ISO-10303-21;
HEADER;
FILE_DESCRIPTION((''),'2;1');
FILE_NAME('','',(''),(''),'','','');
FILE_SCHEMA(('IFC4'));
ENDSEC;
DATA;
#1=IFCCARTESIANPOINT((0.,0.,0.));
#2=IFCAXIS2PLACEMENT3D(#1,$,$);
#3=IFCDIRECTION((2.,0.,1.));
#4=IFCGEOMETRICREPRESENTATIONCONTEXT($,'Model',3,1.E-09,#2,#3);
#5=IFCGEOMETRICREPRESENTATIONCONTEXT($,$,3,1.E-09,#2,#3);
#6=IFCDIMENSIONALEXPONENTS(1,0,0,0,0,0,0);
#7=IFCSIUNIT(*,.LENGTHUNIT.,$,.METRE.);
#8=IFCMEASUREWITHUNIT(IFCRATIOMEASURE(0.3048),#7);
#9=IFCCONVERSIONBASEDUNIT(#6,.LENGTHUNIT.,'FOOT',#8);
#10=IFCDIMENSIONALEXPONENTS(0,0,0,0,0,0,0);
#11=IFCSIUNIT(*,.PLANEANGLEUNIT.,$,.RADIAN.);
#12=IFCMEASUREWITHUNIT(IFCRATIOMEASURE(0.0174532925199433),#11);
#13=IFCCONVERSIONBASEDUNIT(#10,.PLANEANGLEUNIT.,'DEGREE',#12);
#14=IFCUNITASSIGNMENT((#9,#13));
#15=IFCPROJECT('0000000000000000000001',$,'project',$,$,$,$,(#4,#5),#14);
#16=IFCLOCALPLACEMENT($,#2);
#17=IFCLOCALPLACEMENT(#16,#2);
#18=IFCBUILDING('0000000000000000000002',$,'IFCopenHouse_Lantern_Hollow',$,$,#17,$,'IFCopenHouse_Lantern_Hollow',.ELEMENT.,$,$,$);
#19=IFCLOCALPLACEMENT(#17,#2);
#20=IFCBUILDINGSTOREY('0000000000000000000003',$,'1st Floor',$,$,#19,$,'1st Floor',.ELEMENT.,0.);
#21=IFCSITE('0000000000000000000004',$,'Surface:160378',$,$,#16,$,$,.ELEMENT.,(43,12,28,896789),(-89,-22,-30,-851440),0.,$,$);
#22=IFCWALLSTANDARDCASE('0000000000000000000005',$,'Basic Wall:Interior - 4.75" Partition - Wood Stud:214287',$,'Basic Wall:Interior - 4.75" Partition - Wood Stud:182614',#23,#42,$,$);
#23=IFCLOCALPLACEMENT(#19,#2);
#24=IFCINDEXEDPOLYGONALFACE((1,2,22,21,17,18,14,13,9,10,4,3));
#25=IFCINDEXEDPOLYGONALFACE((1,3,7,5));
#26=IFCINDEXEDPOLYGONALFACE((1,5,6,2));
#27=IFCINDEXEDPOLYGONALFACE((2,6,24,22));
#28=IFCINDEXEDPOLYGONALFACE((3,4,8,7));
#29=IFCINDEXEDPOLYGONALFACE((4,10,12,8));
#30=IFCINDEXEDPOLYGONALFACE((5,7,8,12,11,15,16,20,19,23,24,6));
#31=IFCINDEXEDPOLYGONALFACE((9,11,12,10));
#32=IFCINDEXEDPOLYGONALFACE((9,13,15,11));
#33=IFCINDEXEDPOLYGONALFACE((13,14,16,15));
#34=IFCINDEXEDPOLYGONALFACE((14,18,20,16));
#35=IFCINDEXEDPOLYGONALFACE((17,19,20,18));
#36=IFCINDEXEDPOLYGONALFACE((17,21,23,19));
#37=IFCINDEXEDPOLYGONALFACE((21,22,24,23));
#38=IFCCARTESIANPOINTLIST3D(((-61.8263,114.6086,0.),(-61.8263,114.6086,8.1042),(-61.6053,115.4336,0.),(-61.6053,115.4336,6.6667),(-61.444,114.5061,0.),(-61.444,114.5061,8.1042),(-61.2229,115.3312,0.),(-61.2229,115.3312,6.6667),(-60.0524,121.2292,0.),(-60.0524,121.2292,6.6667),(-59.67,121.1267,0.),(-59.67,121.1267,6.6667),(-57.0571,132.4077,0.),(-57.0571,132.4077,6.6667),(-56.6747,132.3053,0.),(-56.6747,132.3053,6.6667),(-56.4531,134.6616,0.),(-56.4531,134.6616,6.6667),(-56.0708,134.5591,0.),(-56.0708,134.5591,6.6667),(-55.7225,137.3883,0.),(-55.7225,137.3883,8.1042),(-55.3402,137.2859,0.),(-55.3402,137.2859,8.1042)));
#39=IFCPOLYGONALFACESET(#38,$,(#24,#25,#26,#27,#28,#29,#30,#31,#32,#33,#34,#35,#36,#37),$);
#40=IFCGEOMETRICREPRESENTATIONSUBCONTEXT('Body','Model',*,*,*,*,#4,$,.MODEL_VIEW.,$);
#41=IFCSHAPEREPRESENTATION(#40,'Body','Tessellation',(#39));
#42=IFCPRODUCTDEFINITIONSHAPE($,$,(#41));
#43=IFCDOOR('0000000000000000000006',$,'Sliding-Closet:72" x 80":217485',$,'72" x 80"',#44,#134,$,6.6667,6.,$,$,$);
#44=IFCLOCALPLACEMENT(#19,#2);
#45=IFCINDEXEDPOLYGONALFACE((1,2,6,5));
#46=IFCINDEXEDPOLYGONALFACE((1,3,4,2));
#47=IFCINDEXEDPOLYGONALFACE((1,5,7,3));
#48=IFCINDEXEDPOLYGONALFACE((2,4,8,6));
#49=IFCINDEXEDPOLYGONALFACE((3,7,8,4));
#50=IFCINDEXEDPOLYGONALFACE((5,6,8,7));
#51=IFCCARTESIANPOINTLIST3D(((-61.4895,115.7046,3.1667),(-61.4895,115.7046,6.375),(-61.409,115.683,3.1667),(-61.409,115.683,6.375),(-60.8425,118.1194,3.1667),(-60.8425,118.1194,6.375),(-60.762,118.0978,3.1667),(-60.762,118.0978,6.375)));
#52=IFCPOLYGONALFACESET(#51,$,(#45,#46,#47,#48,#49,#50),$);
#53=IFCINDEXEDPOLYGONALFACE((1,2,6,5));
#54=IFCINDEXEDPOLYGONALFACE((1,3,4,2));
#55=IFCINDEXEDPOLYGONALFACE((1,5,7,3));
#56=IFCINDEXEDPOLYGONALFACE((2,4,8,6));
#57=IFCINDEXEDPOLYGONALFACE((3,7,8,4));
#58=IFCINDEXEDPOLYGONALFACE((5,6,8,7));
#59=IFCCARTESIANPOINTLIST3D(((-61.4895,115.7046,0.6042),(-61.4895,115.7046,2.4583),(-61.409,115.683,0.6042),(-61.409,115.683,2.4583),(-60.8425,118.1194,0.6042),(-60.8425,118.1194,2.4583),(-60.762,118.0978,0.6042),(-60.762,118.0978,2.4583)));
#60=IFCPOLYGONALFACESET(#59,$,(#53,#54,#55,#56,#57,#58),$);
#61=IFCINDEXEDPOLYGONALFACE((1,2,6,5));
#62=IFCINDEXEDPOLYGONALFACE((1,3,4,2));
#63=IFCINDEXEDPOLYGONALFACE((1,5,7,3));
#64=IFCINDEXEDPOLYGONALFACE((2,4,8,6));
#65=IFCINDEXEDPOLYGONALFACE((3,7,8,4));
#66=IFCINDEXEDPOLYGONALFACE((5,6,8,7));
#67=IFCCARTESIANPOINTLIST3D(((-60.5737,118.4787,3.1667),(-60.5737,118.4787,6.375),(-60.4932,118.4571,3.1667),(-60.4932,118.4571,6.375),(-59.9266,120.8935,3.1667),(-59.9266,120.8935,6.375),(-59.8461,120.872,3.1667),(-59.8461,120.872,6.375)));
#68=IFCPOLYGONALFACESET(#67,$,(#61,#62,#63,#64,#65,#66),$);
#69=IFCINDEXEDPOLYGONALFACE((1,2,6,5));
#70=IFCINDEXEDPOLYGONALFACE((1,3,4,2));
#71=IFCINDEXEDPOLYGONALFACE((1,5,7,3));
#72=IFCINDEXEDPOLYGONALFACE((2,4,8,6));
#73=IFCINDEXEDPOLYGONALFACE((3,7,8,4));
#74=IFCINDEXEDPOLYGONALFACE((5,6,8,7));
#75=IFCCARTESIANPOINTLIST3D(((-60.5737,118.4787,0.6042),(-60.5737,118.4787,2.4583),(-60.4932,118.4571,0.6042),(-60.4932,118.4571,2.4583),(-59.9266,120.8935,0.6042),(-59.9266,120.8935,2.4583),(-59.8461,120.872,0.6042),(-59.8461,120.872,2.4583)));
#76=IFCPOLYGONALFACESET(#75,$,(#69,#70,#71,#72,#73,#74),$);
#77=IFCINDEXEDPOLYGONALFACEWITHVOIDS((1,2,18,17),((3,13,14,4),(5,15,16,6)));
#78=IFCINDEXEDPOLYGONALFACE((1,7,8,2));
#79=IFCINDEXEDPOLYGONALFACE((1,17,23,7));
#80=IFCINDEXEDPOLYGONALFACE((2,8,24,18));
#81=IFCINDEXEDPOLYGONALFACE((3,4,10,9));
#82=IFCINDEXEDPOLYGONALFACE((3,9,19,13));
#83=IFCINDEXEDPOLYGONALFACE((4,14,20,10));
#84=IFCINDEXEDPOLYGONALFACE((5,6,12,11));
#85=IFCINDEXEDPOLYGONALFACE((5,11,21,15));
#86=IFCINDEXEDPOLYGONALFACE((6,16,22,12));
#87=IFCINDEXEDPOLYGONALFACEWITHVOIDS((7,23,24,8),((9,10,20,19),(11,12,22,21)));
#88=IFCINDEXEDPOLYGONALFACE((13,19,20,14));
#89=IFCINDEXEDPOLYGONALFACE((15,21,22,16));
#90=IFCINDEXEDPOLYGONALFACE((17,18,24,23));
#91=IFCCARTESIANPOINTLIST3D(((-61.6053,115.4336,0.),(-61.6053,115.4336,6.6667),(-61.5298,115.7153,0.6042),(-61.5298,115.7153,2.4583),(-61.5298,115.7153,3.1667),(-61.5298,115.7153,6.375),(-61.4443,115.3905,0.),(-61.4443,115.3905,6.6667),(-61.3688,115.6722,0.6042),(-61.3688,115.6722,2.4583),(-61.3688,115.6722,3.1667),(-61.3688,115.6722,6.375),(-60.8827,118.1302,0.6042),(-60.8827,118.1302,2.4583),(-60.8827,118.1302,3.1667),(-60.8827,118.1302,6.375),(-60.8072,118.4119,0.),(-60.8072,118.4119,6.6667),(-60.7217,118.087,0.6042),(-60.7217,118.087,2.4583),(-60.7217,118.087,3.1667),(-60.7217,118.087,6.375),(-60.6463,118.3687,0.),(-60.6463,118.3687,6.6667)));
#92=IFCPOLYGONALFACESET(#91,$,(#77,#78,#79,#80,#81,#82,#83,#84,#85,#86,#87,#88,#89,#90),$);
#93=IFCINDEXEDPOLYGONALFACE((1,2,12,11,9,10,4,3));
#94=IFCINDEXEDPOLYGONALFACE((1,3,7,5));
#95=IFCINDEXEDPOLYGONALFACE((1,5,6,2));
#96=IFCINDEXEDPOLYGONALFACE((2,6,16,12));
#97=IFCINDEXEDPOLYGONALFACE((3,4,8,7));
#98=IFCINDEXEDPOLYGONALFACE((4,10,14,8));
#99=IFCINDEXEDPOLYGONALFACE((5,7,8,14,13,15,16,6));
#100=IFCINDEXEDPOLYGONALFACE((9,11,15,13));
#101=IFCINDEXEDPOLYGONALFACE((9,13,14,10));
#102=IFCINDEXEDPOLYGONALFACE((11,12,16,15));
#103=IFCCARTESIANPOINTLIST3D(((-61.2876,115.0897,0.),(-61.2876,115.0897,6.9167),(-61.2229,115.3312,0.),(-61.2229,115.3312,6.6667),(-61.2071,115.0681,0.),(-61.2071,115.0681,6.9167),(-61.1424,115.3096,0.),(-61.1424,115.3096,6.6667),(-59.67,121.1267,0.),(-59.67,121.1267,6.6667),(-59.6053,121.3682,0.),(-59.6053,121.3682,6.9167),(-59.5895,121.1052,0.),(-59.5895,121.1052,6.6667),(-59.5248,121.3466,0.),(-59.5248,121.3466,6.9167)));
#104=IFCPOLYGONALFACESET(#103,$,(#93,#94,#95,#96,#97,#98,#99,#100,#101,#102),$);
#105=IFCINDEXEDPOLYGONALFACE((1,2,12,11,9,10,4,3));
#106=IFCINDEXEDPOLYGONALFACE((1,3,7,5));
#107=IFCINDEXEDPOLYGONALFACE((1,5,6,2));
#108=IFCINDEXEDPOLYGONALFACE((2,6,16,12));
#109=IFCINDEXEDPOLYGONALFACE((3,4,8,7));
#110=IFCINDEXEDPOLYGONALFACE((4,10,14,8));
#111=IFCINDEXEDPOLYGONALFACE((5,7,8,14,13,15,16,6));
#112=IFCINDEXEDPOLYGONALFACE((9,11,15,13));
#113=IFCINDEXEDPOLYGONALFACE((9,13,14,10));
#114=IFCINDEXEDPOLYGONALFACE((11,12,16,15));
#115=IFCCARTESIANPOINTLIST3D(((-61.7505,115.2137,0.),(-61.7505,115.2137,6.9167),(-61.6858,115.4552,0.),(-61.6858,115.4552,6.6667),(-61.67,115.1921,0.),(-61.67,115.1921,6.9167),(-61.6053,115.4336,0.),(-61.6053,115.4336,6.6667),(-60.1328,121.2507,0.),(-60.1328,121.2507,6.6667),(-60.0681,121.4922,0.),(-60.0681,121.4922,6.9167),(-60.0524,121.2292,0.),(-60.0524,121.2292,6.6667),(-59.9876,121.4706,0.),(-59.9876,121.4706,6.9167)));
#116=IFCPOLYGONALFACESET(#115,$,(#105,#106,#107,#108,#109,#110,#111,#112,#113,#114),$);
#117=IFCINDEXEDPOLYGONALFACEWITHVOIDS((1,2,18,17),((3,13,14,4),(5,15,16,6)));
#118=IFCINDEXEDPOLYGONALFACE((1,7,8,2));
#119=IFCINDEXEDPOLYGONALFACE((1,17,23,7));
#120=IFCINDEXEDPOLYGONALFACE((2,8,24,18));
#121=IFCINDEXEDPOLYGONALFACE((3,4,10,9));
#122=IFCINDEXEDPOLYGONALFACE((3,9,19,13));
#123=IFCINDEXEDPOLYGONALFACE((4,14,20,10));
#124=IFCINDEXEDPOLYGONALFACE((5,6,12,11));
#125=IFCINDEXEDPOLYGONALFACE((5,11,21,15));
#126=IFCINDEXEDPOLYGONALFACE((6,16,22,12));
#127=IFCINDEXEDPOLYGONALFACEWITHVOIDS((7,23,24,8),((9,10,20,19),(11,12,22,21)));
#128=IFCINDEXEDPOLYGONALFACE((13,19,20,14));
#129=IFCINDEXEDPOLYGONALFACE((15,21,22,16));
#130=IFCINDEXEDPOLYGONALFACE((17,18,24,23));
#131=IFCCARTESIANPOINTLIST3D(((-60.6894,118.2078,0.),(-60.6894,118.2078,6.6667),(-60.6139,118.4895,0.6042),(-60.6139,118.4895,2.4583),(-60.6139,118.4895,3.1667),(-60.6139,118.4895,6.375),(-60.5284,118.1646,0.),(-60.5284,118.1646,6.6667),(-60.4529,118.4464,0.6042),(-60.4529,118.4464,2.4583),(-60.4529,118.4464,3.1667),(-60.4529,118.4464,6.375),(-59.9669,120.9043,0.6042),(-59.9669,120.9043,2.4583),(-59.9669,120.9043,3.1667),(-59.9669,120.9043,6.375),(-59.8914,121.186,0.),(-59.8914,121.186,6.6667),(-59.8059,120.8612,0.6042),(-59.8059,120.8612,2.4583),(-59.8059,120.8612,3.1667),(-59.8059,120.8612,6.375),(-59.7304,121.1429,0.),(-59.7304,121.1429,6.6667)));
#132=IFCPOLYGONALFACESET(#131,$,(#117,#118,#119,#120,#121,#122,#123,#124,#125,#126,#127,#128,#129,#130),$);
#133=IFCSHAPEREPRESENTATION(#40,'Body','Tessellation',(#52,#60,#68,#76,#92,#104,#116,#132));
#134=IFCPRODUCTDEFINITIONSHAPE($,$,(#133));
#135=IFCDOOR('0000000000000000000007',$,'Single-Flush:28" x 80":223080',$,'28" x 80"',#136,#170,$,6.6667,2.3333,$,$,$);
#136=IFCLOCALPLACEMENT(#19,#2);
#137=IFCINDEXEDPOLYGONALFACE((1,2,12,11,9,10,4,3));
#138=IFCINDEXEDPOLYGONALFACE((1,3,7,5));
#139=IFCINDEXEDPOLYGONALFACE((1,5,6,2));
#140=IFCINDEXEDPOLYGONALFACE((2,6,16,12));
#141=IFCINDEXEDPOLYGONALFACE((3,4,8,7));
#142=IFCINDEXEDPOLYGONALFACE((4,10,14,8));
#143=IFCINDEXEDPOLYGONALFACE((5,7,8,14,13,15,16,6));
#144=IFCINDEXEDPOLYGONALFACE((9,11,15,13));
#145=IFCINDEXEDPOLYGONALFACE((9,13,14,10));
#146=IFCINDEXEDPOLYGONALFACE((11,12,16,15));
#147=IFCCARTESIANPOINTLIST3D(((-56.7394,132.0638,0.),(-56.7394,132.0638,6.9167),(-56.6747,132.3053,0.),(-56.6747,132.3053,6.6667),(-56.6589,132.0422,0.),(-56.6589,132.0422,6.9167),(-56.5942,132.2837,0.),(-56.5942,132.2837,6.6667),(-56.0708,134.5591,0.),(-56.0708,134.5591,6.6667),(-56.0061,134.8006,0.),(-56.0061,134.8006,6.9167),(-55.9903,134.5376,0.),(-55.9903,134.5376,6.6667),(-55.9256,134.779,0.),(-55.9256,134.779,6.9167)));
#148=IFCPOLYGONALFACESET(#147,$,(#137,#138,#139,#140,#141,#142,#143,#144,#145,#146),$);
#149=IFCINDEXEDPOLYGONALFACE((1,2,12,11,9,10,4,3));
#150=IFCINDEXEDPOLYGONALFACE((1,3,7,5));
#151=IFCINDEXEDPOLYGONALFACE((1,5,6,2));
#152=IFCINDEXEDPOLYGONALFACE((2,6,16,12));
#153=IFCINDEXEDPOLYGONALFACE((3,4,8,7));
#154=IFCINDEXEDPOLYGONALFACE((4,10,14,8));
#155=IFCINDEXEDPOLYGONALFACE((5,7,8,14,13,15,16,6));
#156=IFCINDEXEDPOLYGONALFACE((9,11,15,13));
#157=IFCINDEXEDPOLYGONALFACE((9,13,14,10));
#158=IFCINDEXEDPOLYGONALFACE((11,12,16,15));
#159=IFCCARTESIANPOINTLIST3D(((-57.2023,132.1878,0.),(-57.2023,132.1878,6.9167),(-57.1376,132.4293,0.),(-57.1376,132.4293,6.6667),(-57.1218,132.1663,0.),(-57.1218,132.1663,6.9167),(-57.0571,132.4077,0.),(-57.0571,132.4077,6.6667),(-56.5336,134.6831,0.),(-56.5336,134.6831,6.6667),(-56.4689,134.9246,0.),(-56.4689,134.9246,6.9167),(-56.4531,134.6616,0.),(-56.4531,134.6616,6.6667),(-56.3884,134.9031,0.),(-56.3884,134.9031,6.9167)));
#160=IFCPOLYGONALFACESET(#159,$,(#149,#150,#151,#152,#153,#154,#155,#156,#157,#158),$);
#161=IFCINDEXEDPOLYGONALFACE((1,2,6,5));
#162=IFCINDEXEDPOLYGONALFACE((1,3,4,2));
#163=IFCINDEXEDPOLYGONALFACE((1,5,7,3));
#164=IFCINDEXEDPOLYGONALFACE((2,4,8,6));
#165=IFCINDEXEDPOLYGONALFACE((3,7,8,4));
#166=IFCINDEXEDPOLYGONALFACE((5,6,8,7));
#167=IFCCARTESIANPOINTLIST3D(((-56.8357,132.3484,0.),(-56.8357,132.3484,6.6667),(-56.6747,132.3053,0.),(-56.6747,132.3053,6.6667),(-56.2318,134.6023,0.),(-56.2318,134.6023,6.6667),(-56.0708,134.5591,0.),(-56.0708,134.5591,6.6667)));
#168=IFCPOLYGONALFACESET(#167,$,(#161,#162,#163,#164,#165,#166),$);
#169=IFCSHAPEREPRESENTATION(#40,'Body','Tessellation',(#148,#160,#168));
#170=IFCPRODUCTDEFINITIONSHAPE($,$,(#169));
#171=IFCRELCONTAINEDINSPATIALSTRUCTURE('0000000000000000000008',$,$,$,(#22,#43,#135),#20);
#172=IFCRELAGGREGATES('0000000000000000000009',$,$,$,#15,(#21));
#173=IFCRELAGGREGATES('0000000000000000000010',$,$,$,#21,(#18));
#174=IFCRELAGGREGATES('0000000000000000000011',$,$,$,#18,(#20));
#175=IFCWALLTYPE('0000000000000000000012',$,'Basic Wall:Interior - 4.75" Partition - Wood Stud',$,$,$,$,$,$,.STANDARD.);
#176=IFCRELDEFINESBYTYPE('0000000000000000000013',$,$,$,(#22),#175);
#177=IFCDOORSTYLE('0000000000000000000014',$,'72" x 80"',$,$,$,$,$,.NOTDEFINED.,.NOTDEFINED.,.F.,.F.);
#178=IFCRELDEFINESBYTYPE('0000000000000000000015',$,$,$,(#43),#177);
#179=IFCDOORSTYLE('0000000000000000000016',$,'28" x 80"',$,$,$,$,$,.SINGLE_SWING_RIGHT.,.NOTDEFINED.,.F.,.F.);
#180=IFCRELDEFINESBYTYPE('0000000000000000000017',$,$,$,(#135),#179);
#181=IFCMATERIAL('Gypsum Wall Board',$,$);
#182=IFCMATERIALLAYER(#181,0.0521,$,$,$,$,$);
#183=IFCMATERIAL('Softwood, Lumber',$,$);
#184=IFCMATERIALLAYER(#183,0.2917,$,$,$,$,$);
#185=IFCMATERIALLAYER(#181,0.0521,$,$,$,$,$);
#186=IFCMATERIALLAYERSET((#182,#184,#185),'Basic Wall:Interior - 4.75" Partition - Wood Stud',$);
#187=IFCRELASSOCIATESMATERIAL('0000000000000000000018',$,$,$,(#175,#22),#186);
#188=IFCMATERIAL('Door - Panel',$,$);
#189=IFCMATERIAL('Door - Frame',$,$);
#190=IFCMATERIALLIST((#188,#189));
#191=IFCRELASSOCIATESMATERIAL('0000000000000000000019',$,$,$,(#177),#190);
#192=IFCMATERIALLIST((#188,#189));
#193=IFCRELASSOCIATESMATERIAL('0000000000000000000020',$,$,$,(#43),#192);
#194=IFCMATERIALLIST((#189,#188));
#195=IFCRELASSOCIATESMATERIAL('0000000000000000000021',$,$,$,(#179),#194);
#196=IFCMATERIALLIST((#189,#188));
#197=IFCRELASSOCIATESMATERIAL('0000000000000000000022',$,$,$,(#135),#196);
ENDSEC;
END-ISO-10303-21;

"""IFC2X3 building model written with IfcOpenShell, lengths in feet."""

from ifc_helpers import new_model, entity, si_unit, converted_unit, direction, frame, frame_2d, origin, origin_2d_with_axis, place, context, subcontext, project, spatial, polyline, rectangle, outline, extrude, source, transform, mapped, material, material_list, layer, layer_set, layer_usage, type_object, type_shapes, element, fill, save


model = new_model("IFC2X3")

# Units and contexts
model_context = context("Model", 3, precision=1e-09, world=origin(), true_north=direction((2.0, 0.0, 1.0)))
context_of_model = context(None, 3, precision=1e-09, world=origin(), true_north=direction((2.0, 0.0, 1.0)))
body_context = subcontext(model_context, "Body", "Model", "MODEL_VIEW")
ifc_project = project(units=[converted_unit("LENGTHUNIT", "FOOT", entity("IfcRatioMeasure", 0.3048), si_unit("LENGTHUNIT", "METRE"), dimensions=[1, 0, 0, 0, 0, 0, 0]), converted_unit("PLANEANGLEUNIT", "DEGREE", entity("IfcRatioMeasure", 0.0174532925199433), si_unit("PLANEANGLEUNIT", "RADIAN"), dimensions=[0, 0, 0, 0, 0, 0, 0])], contexts=[model_context, context_of_model])

# Site, building, storey
site_placement = place(None, origin())
site = spatial("IfcSite", under=ifc_project, at=site_placement, Name="Surface:160378", CompositionType="ELEMENT", RefLatitude=(43, 12, 28, 896789), RefLongitude=(-89, -22, -30, -851440), RefElevation=0.0)
building_placement = place(site_placement, origin())
building = spatial("IfcBuilding", under=site, at=building_placement, Name="IFCopenHouse_Lantern_Hollow", LongName="IFCopenHouse_Lantern_Hollow", CompositionType="ELEMENT")
storey_placement = place(building_placement, origin())
storey = spatial("IfcBuildingStorey", under=building, at=storey_placement, Name="1st Floor", LongName="1st Floor", CompositionType="ELEMENT", Elevation=0.0)

# Shared definitions
ifc_material_1 = material(Name="Softwood, Lumber")

# Shared definitions
ifc_material_2 = material(Name="Gypsum Wall Board")

# Shared definitions
ifc_layer_1 = layer(ifc_material_2, 0.0521)
ifc_layer_2 = layer(ifc_material_1, 0.2917)
ifc_layer_3 = layer(ifc_material_2, 0.0521)
ifc_layer_set_1 = layer_set([ifc_layer_1, ifc_layer_2, ifc_layer_3], Name="Basic Wall:Interior - 4.75\" Partition - Wood Stud")
wall_type_1 = type_object("IfcWallType", Name="Basic Wall:Interior - 4.75\" Partition - Wood Stud", PredefinedType="STANDARD", material=ifc_layer_set_1)

# Wall, openings, doors
ifc_layer_usage_1 = layer_usage(ifc_layer_set_1, "AXIS2", "NEGATIVE", 0.1979)
wall_1_placement = place(storey_placement, frame((-61.6352, 114.5573, 0.0), z_axis=(0.0, 0.0, 1.0), x_axis=(0.258819, 0.965926, 0.0)))
wall_1 = element("IfcWallStandardCase", 1, at=wall_1_placement, inside=storey, type_object=wall_type_1, material=ifc_layer_usage_1, Name="Basic Wall:Interior - 4.75\" Partition - Wood Stud:214287", ObjectType="Basic Wall:Interior - 4.75\" Partition - Wood Stud:182614", context=body_context, shape_type="SweptSolid", body=[
    extrude(rectangle(XDim=23.5833, YDim=0.3958, at=frame_2d((11.7917, 0.0), x_axis=(-1.0, 0.0))), origin(), (0.0, 0.0, 1.0), 8.1042),
])
opening_1_placement = place(wall_1_placement, frame((0.8542, -0.1979, 0.0)))
opening_1 = element("IfcOpeningElement", 2, at=opening_1_placement, cuts=wall_1, ObjectType="Opening", context=body_context, shape_type="SweptSolid", body=[
    extrude(rectangle(XDim=6.6667, YDim=6.0, at=frame_2d((3.3333, 3.0), x_axis=(-1.0, 0.0))), frame((0.0, 0.0, 0.0), z_axis=(0.0, 1.0, 0.0), x_axis=(0.0, 0.0, 1.0)), (0.0, 0.0, 1.0), 0.3958),
])
opening_2_placement = place(wall_1_placement, frame((20.7604, 0.1979, 0.0)))
opening_2 = element("IfcOpeningElement", 3, at=opening_2_placement, cuts=wall_1, ObjectType="Opening", context=body_context, shape_type="SweptSolid", body=[
    extrude(rectangle(XDim=2.3333, YDim=6.6667, at=frame_2d((3.3333, 1.1667), x_axis=(0.0, 1.0))), frame((0.0, 0.0, 0.0), z_axis=(0.0, -1.0, 0.0), x_axis=(0.0, 0.0, 1.0)), (0.0, 0.0, 1.0), 0.3958),
])
ifc_material_3 = material(Name="Door - Panel")
ifc_material_4 = material(Name="Door - Frame")
ifc_material_list_1 = material_list([ifc_material_3, ifc_material_4])
ifc_material_list_2 = material_list([ifc_material_3, ifc_material_4])
door_style_1 = type_object("IfcDoorStyle", Name="72\" x 80\"", ConstructionType="NOTDEFINED", OperationType="NOTDEFINED", ParameterTakesPrecedence=False, Sizeable=False, material=ifc_material_list_2)
shared_shape_1 = source(origin(), body_context, "Body", "SweptSolid", [
    extrude(rectangle(XDim=0.0833, YDim=2.5, at=origin_2d_with_axis()), frame((1.5417, 0.3125, 3.1667), z_axis=(0.0, 0.0, 1.0), x_axis=(0.0, 1.0, 0.0)), (0.0, 0.0, 1.0), 3.2083),
    extrude(rectangle(XDim=0.0833, YDim=2.5, at=origin_2d_with_axis()), frame((1.5417, 0.3125, 0.6042), z_axis=(0.0, 0.0, 1.0), x_axis=(0.0, 1.0, 0.0)), (0.0, 0.0, 1.0), 1.8542),
    extrude(rectangle(XDim=0.0833, YDim=2.5, at=origin_2d_with_axis()), frame((4.4583, 0.1458, 3.1667), z_axis=(0.0, 0.0, 1.0), x_axis=(0.0, -1.0, 0.0)), (0.0, 0.0, 1.0), 3.2083),
    extrude(rectangle(XDim=0.0833, YDim=2.5, at=origin_2d_with_axis()), frame((4.4583, 0.1458, 0.6042), z_axis=(0.0, 0.0, 1.0), x_axis=(0.0, -1.0, 0.0)), (0.0, 0.0, 1.0), 1.8542),
    extrude(outline(polyline([(-3.3333, -1.5417), (3.3333, -1.5417), (3.3333, 1.5417), (-3.3333, 1.5417), (-3.3333, -1.5417)]), holes=[polyline([(2.7292, 1.25), (2.7292, -1.25), (0.875, -1.25), (0.875, 1.25), (2.7292, 1.25)]), polyline([(0.1667, 1.25), (0.1667, -1.25), (-3.0417, -1.25), (-3.0417, 1.25), (0.1667, 1.25)])]), frame((1.5417, 0.2292, 3.3333), z_axis=(0.0, 1.0, 0.0), x_axis=(0.0, 0.0, -1.0)), (0.0, 0.0, 1.0), 0.1667),
    extrude(outline(polyline([(-3.3958, -3.25), (3.5208, -3.25), (3.5208, 3.25), (-3.3958, 3.25), (-3.3958, 3.0), (3.2708, 3.0), (3.2708, -3.0), (-3.3958, -3.0), (-3.3958, -3.25)])), frame((3.0, -0.0833, 3.3958), z_axis=(0.0, 1.0, 0.0), x_axis=(0.0, 0.0, 1.0)), (0.0, 0.0, 1.0), 0.0833),
    extrude(outline(polyline([(-3.25, -3.3958), (-3.0, -3.3958), (-3.0, 3.2708), (3.0, 3.2708), (3.0, -3.3958), (3.25, -3.3958), (3.25, 3.5208), (-3.25, 3.5208), (-3.25, -3.3958)])), frame((3.0, 0.3958, 3.3958), z_axis=(0.0, 1.0, 0.0), x_axis=(-1.0, 0.0, 0.0)), (0.0, 0.0, 1.0), 0.0833),
    extrude(outline(polyline([(-1.5417, -3.3333), (1.5417, -3.3333), (1.5417, 3.3333), (-1.5417, 3.3333), (-1.5417, -3.3333)]), holes=[polyline([(1.25, 0.1667), (1.25, -3.0417), (-1.25, -3.0417), (-1.25, 0.1667), (1.25, 0.1667)]), polyline([(1.25, 2.7292), (1.25, 0.875), (-1.25, 0.875), (-1.25, 2.7292), (1.25, 2.7292)])]), frame((4.4583, 0.0625, 3.3333), z_axis=(0.0, 1.0, 0.0), x_axis=(1.0, 0.0, 0.0)), (0.0, 0.0, 1.0), 0.1667),
])
type_shapes(door_style_1, [shared_shape_1])
door_1_placement = place(storey_placement, frame((-61.2229, 115.3312, 0.0), z_axis=(0.0, 0.0, 1.0), x_axis=(0.258819, 0.965926, 0.0)))
door_1 = element("IfcDoor", 4, at=door_1_placement, inside=storey, type_object=door_style_1, material=ifc_material_list_1, Name="Sliding-Closet:72\" x 80\":217485", ObjectType="72\" x 80\"", OverallHeight=6.6667, OverallWidth=6.0, context=body_context, shape_type="MappedRepresentation", body=[
    mapped(shared_shape_1, transform((0.0, 0.0, 0.0), scale=1.0)),
])
fill(opening_1, door_1)
ifc_material_list_3 = material_list([ifc_material_4, ifc_material_3])
ifc_material_list_4 = material_list([ifc_material_4, ifc_material_3])
door_style_2 = type_object("IfcDoorStyle", Name="28\" x 80\"", ConstructionType="NOTDEFINED", OperationType="SINGLE_SWING_RIGHT", ParameterTakesPrecedence=False, Sizeable=False, material=ifc_material_list_4)
shared_shape_2 = source(origin(), body_context, "Body", "SweptSolid", [
    extrude(outline(polyline([(-1.4167, -3.5208), (1.4167, -3.5208), (1.4167, 3.3958), (1.1667, 3.3958), (1.1667, -3.2708), (-1.1667, -3.2708), (-1.1667, 3.3958), (-1.4167, 3.3958), (-1.4167, -3.5208)])), frame((1.1667, 0.3958, 3.3958), z_axis=(0.0, 1.0, 0.0), x_axis=(1.0, 0.0, 0.0)), (0.0, 0.0, 1.0), 0.0833),
    extrude(outline(polyline([(-3.5208, -1.4167), (3.3958, -1.4167), (3.3958, -1.1667), (-3.2708, -1.1667), (-3.2708, 1.1667), (3.3958, 1.1667), (3.3958, 1.4167), (-3.5208, 1.4167), (-3.5208, -1.4167)])), frame((1.1667, -0.0833, 3.3958), z_axis=(0.0, 1.0, 0.0), x_axis=(0.0, 0.0, -1.0)), (0.0, 0.0, 1.0), 0.0833),
    extrude(rectangle(XDim=0.1667, YDim=2.3333, at=frame_2d((0.0, 0.0), x_axis=(1.0, 0.0))), frame((1.1667, 0.3125, 0.0), z_axis=(0.0, 0.0, 1.0), x_axis=(0.0, 1.0, 0.0)), (0.0, 0.0, 1.0), 6.6667),
])
type_shapes(door_style_2, [shared_shape_2])
door_2_placement = place(storey_placement, frame((-56.4531, 134.6616, 0.0), z_axis=(0.0, 0.0, 1.0), x_axis=(-0.258819, -0.965926, 0.0)))
door_2 = element("IfcDoor", 5, at=door_2_placement, inside=storey, type_object=door_style_2, material=ifc_material_list_3, Name="Single-Flush:28\" x 80\":223080", ObjectType="28\" x 80\"", OverallHeight=6.6667, OverallWidth=2.3333, context=body_context, shape_type="MappedRepresentation", body=[
    mapped(shared_shape_2, transform((0.0, 0.0, 0.0), scale=1.0)),
])
fill(opening_2, door_2)

save(model, "model.ifc")
